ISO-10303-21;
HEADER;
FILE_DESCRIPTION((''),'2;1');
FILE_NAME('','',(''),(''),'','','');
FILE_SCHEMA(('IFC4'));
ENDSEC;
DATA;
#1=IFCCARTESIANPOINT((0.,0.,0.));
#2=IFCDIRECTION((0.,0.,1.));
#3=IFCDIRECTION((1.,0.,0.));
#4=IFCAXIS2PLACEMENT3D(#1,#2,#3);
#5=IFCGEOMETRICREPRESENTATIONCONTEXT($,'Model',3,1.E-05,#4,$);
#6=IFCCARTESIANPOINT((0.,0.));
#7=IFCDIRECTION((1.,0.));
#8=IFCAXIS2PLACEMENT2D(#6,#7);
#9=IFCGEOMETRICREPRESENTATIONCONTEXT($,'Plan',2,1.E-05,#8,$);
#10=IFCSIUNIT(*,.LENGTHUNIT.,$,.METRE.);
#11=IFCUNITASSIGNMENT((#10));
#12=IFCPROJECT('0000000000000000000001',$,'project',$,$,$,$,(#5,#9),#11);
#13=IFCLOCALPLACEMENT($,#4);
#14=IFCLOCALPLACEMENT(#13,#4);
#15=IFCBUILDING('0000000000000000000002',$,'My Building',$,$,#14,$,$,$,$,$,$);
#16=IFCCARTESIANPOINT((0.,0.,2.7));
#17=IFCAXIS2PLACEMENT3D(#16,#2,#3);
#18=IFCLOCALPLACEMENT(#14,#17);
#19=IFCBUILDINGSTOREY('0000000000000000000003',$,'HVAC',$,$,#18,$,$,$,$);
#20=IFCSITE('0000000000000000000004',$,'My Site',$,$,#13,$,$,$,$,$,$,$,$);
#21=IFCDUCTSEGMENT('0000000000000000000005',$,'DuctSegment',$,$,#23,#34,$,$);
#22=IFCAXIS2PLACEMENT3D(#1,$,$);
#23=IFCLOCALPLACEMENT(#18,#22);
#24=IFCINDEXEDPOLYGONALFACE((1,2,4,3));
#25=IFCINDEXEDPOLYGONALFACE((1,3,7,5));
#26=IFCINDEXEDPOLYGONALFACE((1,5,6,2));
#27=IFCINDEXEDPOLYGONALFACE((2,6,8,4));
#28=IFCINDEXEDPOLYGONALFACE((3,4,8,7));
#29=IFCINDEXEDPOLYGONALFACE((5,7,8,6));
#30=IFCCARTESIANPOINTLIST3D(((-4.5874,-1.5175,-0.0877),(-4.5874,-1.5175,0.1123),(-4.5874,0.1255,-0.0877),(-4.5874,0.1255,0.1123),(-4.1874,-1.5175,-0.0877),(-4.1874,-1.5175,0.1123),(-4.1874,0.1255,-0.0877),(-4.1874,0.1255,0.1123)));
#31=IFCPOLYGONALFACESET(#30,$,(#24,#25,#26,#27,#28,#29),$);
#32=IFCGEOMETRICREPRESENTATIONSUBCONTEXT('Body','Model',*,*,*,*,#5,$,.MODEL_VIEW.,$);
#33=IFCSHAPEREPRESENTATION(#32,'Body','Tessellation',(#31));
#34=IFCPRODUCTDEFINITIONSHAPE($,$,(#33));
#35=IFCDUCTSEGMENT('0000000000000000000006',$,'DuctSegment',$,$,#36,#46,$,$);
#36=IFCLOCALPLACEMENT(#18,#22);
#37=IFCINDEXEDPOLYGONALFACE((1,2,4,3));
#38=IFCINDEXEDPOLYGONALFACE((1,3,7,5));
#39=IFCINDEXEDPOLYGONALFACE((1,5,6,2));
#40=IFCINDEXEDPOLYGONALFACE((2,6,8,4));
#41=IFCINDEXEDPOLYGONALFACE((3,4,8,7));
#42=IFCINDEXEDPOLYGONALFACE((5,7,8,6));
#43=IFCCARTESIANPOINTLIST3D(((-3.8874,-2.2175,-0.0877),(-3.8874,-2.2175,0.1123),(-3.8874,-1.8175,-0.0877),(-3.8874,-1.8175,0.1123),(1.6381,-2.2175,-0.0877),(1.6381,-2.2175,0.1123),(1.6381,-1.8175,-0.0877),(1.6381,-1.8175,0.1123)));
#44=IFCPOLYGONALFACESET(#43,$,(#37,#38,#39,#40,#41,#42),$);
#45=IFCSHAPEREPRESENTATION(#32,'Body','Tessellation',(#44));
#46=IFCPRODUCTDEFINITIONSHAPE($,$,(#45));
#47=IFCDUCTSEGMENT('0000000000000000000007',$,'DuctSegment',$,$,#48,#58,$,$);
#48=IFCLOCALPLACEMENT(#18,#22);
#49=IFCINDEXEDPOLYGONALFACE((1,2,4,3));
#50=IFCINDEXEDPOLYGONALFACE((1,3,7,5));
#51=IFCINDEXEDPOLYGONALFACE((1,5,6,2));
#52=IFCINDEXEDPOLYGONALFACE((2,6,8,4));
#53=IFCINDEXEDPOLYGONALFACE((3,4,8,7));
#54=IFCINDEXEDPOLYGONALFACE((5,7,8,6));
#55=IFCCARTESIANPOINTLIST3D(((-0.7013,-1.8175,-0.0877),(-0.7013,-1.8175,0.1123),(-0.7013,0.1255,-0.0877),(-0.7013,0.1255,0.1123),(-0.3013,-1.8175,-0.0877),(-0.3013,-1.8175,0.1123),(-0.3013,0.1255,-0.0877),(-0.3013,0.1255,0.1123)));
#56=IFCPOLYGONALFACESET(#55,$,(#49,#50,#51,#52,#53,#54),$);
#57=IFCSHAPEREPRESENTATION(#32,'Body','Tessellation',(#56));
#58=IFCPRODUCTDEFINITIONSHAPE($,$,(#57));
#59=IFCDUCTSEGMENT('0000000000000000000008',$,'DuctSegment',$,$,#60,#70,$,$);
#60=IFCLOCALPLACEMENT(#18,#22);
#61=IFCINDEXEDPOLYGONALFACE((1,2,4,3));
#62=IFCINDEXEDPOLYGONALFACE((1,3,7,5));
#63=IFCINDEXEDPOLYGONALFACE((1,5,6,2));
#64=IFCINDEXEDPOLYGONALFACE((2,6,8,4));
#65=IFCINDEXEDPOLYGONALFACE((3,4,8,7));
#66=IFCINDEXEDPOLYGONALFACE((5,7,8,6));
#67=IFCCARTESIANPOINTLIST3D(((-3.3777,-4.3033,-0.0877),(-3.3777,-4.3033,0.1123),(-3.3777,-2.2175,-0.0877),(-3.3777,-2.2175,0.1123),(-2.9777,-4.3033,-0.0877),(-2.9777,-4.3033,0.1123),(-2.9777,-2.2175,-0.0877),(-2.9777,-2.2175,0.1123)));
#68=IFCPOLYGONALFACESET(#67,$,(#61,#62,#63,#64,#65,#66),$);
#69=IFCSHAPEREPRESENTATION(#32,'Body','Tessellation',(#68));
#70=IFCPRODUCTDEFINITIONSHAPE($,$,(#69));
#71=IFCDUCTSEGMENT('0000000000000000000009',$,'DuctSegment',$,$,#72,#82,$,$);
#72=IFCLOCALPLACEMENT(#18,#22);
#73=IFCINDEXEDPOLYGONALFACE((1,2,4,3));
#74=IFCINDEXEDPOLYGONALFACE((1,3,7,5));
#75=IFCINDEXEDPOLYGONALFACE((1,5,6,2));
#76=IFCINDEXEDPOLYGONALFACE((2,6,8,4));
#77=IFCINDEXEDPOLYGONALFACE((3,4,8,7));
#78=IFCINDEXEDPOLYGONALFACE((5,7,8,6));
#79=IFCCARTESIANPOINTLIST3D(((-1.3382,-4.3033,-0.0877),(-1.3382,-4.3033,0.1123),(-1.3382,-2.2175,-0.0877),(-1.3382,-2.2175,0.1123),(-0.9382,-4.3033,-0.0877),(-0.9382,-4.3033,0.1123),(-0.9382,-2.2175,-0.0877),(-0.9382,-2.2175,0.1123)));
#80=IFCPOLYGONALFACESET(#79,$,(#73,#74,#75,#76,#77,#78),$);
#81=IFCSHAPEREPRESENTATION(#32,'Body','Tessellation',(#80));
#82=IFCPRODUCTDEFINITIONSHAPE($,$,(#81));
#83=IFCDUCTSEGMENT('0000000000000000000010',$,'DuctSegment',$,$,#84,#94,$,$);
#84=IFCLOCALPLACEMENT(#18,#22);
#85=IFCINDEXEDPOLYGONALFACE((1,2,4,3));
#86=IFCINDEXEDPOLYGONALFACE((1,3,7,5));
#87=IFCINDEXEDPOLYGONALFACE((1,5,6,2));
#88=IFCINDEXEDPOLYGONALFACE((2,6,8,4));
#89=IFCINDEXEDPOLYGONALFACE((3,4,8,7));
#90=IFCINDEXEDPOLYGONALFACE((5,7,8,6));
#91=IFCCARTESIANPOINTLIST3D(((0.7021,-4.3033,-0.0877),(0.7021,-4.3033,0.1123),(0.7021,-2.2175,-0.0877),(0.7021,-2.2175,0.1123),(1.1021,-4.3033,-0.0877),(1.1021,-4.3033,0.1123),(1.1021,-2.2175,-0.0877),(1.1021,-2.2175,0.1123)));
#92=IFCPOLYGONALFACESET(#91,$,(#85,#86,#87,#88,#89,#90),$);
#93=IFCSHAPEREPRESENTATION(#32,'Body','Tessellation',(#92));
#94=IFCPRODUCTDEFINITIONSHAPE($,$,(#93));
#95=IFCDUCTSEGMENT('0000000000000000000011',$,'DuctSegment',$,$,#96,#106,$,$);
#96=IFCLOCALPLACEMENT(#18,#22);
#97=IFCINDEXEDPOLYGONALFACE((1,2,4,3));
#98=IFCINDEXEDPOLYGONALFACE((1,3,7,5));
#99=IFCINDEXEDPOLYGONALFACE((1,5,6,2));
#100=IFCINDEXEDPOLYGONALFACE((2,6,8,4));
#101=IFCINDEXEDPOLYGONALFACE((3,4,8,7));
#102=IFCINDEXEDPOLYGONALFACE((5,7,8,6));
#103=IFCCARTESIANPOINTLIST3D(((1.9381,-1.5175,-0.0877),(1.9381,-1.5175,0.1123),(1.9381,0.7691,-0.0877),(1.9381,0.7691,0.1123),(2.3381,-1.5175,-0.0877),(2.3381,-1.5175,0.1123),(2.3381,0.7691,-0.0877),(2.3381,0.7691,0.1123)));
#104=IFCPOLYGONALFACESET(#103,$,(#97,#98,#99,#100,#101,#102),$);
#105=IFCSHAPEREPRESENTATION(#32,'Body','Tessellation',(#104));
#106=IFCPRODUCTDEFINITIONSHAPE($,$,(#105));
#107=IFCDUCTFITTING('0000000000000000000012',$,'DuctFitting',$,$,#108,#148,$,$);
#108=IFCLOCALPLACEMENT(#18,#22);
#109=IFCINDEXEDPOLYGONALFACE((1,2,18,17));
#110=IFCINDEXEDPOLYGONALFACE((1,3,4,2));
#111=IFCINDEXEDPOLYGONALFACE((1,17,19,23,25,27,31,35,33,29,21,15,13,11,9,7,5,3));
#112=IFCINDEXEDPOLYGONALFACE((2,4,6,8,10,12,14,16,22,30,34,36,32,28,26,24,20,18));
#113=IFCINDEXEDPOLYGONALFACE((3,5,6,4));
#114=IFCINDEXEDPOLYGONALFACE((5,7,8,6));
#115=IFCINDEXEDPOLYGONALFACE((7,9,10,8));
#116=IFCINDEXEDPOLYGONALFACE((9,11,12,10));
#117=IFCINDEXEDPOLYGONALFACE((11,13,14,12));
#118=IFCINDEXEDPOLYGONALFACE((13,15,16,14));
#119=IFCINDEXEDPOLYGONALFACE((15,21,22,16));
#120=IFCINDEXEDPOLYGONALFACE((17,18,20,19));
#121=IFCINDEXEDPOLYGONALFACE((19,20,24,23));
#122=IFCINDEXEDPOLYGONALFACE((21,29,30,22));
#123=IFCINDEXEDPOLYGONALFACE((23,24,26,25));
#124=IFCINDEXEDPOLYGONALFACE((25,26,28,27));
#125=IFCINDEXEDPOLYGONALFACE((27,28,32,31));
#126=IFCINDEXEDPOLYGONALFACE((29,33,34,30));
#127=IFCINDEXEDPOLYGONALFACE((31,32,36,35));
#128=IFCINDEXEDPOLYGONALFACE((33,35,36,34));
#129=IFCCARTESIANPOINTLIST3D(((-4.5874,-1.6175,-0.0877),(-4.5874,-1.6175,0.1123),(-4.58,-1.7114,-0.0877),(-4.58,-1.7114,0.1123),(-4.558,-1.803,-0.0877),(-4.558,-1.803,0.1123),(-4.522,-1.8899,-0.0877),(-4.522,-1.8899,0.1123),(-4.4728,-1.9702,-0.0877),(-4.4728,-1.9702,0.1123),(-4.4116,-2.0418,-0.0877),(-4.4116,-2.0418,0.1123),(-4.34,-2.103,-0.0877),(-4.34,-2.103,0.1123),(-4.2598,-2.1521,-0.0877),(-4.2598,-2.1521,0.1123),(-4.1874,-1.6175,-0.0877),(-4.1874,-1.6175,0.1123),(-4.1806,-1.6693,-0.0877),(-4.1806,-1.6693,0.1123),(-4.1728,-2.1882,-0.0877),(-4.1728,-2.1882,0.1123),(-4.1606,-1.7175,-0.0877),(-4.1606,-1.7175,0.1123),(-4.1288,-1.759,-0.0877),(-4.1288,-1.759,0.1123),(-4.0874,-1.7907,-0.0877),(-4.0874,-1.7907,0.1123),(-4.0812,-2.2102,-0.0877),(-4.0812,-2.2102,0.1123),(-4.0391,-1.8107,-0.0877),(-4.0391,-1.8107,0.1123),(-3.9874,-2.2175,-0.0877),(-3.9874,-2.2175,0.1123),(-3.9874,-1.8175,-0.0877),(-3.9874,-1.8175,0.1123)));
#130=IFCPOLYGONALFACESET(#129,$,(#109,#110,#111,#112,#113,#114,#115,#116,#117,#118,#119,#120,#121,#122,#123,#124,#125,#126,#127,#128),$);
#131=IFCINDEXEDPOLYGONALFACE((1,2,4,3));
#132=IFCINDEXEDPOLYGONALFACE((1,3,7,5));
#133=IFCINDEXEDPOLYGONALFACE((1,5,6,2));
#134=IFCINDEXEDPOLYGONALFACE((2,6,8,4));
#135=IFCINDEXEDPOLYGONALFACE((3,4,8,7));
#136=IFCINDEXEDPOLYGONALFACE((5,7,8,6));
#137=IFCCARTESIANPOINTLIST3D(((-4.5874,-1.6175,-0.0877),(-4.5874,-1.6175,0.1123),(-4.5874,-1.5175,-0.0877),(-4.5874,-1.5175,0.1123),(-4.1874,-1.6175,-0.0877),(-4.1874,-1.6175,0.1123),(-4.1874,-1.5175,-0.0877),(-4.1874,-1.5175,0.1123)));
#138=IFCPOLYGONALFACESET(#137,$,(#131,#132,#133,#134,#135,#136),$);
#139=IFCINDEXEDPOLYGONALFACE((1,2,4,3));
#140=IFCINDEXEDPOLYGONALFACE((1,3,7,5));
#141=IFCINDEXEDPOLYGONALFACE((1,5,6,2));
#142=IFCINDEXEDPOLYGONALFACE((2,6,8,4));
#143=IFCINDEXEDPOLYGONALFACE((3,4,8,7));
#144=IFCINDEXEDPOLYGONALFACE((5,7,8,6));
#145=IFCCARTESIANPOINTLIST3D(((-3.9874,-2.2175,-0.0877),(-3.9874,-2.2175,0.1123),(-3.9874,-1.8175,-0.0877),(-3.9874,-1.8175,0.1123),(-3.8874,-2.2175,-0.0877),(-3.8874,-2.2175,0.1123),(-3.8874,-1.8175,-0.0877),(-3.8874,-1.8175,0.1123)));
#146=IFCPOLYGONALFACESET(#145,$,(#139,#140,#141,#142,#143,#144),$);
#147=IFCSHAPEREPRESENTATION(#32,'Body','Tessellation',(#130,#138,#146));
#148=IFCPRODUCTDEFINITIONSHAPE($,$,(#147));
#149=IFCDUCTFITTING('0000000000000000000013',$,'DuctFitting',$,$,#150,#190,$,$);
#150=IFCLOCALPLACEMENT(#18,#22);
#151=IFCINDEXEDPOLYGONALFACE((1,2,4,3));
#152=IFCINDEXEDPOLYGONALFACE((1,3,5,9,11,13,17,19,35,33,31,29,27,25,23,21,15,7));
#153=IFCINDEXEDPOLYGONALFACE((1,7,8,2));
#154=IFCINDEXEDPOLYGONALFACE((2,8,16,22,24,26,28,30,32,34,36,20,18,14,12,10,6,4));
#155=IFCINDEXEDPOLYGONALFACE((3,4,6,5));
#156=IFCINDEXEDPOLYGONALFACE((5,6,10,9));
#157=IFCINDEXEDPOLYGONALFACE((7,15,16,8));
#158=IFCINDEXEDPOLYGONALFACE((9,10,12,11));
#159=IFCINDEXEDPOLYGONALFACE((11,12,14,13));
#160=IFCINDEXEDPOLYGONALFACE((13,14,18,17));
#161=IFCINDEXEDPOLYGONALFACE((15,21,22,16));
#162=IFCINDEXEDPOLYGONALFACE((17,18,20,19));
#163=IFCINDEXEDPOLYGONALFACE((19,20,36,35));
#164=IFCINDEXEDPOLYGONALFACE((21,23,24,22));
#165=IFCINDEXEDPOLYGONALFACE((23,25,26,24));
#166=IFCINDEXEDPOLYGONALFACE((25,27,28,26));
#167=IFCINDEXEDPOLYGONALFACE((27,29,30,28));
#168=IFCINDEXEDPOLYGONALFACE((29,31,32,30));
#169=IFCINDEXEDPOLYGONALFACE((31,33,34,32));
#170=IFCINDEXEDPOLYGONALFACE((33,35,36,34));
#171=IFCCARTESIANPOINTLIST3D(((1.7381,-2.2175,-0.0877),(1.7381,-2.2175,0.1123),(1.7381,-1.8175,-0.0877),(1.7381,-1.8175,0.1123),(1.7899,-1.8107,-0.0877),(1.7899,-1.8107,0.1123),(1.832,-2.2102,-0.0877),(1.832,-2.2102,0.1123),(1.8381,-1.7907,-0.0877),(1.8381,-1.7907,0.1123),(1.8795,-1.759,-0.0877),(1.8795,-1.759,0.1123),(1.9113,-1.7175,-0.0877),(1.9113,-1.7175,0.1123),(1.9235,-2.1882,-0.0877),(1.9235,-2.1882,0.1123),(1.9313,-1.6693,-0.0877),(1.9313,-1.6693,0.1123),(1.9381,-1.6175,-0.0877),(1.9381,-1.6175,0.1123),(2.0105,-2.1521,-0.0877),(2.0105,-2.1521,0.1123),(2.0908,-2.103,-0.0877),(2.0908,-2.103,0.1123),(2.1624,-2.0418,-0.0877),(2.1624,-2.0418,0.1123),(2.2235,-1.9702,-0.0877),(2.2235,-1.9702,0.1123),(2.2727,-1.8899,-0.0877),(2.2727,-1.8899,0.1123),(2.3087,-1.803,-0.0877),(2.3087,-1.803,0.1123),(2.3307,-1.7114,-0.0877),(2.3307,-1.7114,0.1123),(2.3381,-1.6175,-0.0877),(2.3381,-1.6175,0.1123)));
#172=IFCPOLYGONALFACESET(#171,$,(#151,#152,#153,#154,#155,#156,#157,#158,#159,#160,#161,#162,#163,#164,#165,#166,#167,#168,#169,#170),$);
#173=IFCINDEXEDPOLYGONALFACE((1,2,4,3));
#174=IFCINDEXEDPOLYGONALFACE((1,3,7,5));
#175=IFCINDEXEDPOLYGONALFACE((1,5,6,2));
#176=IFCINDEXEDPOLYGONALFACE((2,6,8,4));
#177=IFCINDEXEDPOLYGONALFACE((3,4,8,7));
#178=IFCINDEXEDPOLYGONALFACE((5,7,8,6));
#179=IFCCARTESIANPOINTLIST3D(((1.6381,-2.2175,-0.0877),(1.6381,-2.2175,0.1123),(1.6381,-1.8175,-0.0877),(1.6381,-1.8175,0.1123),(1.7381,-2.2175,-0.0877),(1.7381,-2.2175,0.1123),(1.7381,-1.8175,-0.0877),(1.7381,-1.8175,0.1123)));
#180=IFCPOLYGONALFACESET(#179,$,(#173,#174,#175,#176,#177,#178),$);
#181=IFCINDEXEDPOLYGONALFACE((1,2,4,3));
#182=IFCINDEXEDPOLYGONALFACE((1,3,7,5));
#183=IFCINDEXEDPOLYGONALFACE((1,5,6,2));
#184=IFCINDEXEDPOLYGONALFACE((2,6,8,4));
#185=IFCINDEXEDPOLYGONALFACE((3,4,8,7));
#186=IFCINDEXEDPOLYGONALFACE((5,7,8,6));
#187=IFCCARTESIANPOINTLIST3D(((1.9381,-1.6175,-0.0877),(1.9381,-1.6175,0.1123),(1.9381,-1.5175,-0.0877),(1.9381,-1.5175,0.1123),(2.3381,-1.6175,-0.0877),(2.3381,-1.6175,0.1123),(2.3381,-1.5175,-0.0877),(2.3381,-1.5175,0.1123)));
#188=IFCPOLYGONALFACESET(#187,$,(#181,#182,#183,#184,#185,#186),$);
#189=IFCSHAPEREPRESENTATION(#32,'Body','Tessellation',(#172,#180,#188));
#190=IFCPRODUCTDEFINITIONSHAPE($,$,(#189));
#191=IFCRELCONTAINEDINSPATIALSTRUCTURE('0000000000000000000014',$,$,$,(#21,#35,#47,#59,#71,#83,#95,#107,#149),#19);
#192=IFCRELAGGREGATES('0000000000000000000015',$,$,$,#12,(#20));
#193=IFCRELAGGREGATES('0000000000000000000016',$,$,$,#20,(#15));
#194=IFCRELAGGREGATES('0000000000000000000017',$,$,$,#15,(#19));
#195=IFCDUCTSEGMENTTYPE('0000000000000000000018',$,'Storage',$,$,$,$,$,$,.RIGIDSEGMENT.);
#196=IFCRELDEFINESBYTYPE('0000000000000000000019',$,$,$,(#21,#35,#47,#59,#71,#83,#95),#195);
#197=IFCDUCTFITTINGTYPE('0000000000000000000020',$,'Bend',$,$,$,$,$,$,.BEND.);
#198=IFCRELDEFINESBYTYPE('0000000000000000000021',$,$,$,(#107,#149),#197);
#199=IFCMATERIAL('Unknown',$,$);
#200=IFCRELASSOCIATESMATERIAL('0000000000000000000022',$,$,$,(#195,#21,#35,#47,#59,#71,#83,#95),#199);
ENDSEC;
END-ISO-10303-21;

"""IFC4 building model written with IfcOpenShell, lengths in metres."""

from ifc_helpers import new_model, si_unit, frame, origin_with_axes, origin_2d_with_axis, place, context, subcontext, project, spatial, line, arc, indexed_curve, rectangle, outline, extrude, source, transform, mapped, material, material_profile, profile_set, profile_usage, type_object, type_shapes, element, save


model = new_model("IFC4")

# Units and contexts
model_context = context("Model", 3, precision=1e-05, world=origin_with_axes())
plan_context = context("Plan", 2, precision=1e-05, world=origin_2d_with_axis())
body_context = subcontext(model_context, "Body", "Model", "MODEL_VIEW")
ifc_project = project(units=[si_unit("LENGTHUNIT", "METRE")], contexts=[model_context, plan_context])

# Site, building, storey
site_placement = place(None, origin_with_axes())
site = spatial("IfcSite", under=ifc_project, at=site_placement, Name="My Site")
building_placement = place(site_placement, origin_with_axes())
building = spatial("IfcBuilding", under=site, at=building_placement, Name="My Building")
storey_placement = place(building_placement, frame((0.0, 0.0, 2.7), z_axis=(0.0, 0.0, 1.0), x_axis=(1.0, 0.0, 0.0)))
storey = spatial("IfcBuildingStorey", under=building, at=storey_placement, Name="HVAC")

# Duct segments
ifc_material = material(Name="Unknown")
ifc_material_profile = material_profile(ifc_material, rectangle(XDim=0.4, YDim=0.2))
ifc_profile_set = profile_set([ifc_material_profile])
ifc_profile_usage_1 = profile_usage(ifc_profile_set, cardinal=5)
duct_segment_type = type_object("IfcDuctSegmentType", Name="Storage", PredefinedType="RIGIDSEGMENT", material=ifc_profile_set)
duct_segment_1_placement = place(storey_placement, frame((-4.3874, 0.1255, 0.0123), z_axis=(0.0, -1.0, 0.0), x_axis=(-1.0, 0.0, 0.0)))
element("IfcDuctSegment", 1, at=duct_segment_1_placement, inside=storey, type_object=duct_segment_type, material=ifc_profile_usage_1, Name="DuctSegment", context=body_context, shape_type="SweptSolid", body=[
    extrude(rectangle(XDim=0.4, YDim=0.2), origin_with_axes(), (0.0, 0.0, 1.0), 1.643),
])
ifc_profile_usage_2 = profile_usage(ifc_profile_set, cardinal=5)
duct_segment_2_placement = place(storey_placement, frame((-3.8874, -2.0175, 0.0123), z_axis=(1.0, 0.0, 0.0), x_axis=(0.0, -1.0, 0.0)))
element("IfcDuctSegment", 2, at=duct_segment_2_placement, inside=storey, type_object=duct_segment_type, material=ifc_profile_usage_2, Name="DuctSegment", context=body_context, shape_type="SweptSolid", body=[
    extrude(rectangle(XDim=0.4, YDim=0.2), origin_with_axes(), (0.0, 0.0, 1.0), 5.5255),
])
ifc_profile_usage_3 = profile_usage(ifc_profile_set, cardinal=5)
duct_segment_3_placement = place(storey_placement, frame((-0.5013, 0.1255, 0.0123), z_axis=(0.0, -1.0, 0.0), x_axis=(-1.0, 0.0, 0.0)))
element("IfcDuctSegment", 3, at=duct_segment_3_placement, inside=storey, type_object=duct_segment_type, material=ifc_profile_usage_3, Name="DuctSegment", context=body_context, shape_type="SweptSolid", body=[
    extrude(rectangle(XDim=0.4, YDim=0.2), origin_with_axes(), (0.0, 0.0, 1.0), 1.943),
])
ifc_profile_usage_4 = profile_usage(ifc_profile_set, cardinal=5)
duct_segment_4_placement = place(storey_placement, frame((-3.1777, -2.2175, 0.0123), z_axis=(0.0, -1.0, 0.0), x_axis=(-1.0, 0.0, 0.0)))
element("IfcDuctSegment", 4, at=duct_segment_4_placement, inside=storey, type_object=duct_segment_type, material=ifc_profile_usage_4, Name="DuctSegment", context=body_context, shape_type="SweptSolid", body=[
    extrude(rectangle(XDim=0.4, YDim=0.2), origin_with_axes(), (0.0, 0.0, 1.0), 2.0857),
])
ifc_profile_usage_5 = profile_usage(ifc_profile_set, cardinal=5)
duct_segment_5_placement = place(storey_placement, frame((-1.1382, -2.2175, 0.0123), z_axis=(0.0, -1.0, 0.0), x_axis=(-1.0, 0.0, 0.0)))
element("IfcDuctSegment", 5, at=duct_segment_5_placement, inside=storey, type_object=duct_segment_type, material=ifc_profile_usage_5, Name="DuctSegment", context=body_context, shape_type="SweptSolid", body=[
    extrude(rectangle(XDim=0.4, YDim=0.2), origin_with_axes(), (0.0, 0.0, 1.0), 2.0857),
])
ifc_profile_usage_6 = profile_usage(ifc_profile_set, cardinal=5)
duct_segment_6_placement = place(storey_placement, frame((0.9021, -2.2175, 0.0123), z_axis=(0.0, -1.0, 0.0), x_axis=(-1.0, 0.0, 0.0)))
element("IfcDuctSegment", 6, at=duct_segment_6_placement, inside=storey, type_object=duct_segment_type, material=ifc_profile_usage_6, Name="DuctSegment", context=body_context, shape_type="SweptSolid", body=[
    extrude(rectangle(XDim=0.4, YDim=0.2), origin_with_axes(), (0.0, 0.0, 1.0), 2.0857),
])
ifc_profile_usage_7 = profile_usage(ifc_profile_set, cardinal=5)
duct_segment_7_placement = place(storey_placement, frame((2.1381, 0.7691, 0.0123), z_axis=(0.0, -1.0, 0.0), x_axis=(-1.0, 0.0, 0.0)))
element("IfcDuctSegment", 7, at=duct_segment_7_placement, inside=storey, type_object=duct_segment_type, material=ifc_profile_usage_7, Name="DuctSegment", context=body_context, shape_type="SweptSolid", body=[
    extrude(rectangle(XDim=0.4, YDim=0.2), origin_with_axes(), (0.0, 0.0, 1.0), 2.2867),
])

# Duct fittings
duct_fitting_type = type_object("IfcDuctFittingType", Name="Bend", PredefinedType="BEND")
shared_shape = source(origin_with_axes(), body_context, "Body", "SweptSolid", [
    extrude(outline(indexed_curve([(-0.2, 0.0), (-0.2586, 0.1414), (-0.4, 0.2), (-0.4, 0.6), (0.0243, 0.4243), (0.2, 0.0)], segments=[arc(1, 2, 3), line(3, 4), arc(4, 5, 6), line(6, 1)])), frame((0.0, -0.1, 0.1), z_axis=(0.0, -1.0, 0.0), x_axis=(1.0, 0.0, 0.0)), (0.0, 0.0, -1.0), 0.2),
    extrude(rectangle(XDim=0.4, YDim=0.2), origin_with_axes(), (0.0, 0.0, 1.0), 0.1),
    extrude(rectangle(XDim=0.4, YDim=0.2), frame((-0.4, 0.0, 0.5), z_axis=(-1.0, 0.0, 0.0), x_axis=(0.0, 0.0, -1.0)), (0.0, 0.0, 1.0), 0.1),
])
type_shapes(duct_fitting_type, [shared_shape])
for number, where, z_axis, x_axis, name in (
    (8, (-4.3874, -1.5175, 0.0123), (0.0, -1.0, 0.0), (-1.0, 0.0, 0.0), "DuctFitting"),
    (9, (1.6381, -2.0175, 0.0123), (1.0, 0.0, 0.0), (0.0, -1.0, 0.0), "DuctFitting"),
):
    element("IfcDuctFitting", number, at=place(storey_placement, frame(where, z_axis=z_axis, x_axis=x_axis)), inside=storey, type_object=duct_fitting_type, Name=name, context=body_context, shape_type="MappedRepresentation", body=[
        mapped(shared_shape, transform((0.0, 0.0, 0.0), x_axis=(1.0, 0.0, 0.0), y_axis=(0.0, 1.0, 0.0), z_axis=(0.0, 0.0, 1.0), scale=1.0)),
    ])

save(model, "model.ifc")
